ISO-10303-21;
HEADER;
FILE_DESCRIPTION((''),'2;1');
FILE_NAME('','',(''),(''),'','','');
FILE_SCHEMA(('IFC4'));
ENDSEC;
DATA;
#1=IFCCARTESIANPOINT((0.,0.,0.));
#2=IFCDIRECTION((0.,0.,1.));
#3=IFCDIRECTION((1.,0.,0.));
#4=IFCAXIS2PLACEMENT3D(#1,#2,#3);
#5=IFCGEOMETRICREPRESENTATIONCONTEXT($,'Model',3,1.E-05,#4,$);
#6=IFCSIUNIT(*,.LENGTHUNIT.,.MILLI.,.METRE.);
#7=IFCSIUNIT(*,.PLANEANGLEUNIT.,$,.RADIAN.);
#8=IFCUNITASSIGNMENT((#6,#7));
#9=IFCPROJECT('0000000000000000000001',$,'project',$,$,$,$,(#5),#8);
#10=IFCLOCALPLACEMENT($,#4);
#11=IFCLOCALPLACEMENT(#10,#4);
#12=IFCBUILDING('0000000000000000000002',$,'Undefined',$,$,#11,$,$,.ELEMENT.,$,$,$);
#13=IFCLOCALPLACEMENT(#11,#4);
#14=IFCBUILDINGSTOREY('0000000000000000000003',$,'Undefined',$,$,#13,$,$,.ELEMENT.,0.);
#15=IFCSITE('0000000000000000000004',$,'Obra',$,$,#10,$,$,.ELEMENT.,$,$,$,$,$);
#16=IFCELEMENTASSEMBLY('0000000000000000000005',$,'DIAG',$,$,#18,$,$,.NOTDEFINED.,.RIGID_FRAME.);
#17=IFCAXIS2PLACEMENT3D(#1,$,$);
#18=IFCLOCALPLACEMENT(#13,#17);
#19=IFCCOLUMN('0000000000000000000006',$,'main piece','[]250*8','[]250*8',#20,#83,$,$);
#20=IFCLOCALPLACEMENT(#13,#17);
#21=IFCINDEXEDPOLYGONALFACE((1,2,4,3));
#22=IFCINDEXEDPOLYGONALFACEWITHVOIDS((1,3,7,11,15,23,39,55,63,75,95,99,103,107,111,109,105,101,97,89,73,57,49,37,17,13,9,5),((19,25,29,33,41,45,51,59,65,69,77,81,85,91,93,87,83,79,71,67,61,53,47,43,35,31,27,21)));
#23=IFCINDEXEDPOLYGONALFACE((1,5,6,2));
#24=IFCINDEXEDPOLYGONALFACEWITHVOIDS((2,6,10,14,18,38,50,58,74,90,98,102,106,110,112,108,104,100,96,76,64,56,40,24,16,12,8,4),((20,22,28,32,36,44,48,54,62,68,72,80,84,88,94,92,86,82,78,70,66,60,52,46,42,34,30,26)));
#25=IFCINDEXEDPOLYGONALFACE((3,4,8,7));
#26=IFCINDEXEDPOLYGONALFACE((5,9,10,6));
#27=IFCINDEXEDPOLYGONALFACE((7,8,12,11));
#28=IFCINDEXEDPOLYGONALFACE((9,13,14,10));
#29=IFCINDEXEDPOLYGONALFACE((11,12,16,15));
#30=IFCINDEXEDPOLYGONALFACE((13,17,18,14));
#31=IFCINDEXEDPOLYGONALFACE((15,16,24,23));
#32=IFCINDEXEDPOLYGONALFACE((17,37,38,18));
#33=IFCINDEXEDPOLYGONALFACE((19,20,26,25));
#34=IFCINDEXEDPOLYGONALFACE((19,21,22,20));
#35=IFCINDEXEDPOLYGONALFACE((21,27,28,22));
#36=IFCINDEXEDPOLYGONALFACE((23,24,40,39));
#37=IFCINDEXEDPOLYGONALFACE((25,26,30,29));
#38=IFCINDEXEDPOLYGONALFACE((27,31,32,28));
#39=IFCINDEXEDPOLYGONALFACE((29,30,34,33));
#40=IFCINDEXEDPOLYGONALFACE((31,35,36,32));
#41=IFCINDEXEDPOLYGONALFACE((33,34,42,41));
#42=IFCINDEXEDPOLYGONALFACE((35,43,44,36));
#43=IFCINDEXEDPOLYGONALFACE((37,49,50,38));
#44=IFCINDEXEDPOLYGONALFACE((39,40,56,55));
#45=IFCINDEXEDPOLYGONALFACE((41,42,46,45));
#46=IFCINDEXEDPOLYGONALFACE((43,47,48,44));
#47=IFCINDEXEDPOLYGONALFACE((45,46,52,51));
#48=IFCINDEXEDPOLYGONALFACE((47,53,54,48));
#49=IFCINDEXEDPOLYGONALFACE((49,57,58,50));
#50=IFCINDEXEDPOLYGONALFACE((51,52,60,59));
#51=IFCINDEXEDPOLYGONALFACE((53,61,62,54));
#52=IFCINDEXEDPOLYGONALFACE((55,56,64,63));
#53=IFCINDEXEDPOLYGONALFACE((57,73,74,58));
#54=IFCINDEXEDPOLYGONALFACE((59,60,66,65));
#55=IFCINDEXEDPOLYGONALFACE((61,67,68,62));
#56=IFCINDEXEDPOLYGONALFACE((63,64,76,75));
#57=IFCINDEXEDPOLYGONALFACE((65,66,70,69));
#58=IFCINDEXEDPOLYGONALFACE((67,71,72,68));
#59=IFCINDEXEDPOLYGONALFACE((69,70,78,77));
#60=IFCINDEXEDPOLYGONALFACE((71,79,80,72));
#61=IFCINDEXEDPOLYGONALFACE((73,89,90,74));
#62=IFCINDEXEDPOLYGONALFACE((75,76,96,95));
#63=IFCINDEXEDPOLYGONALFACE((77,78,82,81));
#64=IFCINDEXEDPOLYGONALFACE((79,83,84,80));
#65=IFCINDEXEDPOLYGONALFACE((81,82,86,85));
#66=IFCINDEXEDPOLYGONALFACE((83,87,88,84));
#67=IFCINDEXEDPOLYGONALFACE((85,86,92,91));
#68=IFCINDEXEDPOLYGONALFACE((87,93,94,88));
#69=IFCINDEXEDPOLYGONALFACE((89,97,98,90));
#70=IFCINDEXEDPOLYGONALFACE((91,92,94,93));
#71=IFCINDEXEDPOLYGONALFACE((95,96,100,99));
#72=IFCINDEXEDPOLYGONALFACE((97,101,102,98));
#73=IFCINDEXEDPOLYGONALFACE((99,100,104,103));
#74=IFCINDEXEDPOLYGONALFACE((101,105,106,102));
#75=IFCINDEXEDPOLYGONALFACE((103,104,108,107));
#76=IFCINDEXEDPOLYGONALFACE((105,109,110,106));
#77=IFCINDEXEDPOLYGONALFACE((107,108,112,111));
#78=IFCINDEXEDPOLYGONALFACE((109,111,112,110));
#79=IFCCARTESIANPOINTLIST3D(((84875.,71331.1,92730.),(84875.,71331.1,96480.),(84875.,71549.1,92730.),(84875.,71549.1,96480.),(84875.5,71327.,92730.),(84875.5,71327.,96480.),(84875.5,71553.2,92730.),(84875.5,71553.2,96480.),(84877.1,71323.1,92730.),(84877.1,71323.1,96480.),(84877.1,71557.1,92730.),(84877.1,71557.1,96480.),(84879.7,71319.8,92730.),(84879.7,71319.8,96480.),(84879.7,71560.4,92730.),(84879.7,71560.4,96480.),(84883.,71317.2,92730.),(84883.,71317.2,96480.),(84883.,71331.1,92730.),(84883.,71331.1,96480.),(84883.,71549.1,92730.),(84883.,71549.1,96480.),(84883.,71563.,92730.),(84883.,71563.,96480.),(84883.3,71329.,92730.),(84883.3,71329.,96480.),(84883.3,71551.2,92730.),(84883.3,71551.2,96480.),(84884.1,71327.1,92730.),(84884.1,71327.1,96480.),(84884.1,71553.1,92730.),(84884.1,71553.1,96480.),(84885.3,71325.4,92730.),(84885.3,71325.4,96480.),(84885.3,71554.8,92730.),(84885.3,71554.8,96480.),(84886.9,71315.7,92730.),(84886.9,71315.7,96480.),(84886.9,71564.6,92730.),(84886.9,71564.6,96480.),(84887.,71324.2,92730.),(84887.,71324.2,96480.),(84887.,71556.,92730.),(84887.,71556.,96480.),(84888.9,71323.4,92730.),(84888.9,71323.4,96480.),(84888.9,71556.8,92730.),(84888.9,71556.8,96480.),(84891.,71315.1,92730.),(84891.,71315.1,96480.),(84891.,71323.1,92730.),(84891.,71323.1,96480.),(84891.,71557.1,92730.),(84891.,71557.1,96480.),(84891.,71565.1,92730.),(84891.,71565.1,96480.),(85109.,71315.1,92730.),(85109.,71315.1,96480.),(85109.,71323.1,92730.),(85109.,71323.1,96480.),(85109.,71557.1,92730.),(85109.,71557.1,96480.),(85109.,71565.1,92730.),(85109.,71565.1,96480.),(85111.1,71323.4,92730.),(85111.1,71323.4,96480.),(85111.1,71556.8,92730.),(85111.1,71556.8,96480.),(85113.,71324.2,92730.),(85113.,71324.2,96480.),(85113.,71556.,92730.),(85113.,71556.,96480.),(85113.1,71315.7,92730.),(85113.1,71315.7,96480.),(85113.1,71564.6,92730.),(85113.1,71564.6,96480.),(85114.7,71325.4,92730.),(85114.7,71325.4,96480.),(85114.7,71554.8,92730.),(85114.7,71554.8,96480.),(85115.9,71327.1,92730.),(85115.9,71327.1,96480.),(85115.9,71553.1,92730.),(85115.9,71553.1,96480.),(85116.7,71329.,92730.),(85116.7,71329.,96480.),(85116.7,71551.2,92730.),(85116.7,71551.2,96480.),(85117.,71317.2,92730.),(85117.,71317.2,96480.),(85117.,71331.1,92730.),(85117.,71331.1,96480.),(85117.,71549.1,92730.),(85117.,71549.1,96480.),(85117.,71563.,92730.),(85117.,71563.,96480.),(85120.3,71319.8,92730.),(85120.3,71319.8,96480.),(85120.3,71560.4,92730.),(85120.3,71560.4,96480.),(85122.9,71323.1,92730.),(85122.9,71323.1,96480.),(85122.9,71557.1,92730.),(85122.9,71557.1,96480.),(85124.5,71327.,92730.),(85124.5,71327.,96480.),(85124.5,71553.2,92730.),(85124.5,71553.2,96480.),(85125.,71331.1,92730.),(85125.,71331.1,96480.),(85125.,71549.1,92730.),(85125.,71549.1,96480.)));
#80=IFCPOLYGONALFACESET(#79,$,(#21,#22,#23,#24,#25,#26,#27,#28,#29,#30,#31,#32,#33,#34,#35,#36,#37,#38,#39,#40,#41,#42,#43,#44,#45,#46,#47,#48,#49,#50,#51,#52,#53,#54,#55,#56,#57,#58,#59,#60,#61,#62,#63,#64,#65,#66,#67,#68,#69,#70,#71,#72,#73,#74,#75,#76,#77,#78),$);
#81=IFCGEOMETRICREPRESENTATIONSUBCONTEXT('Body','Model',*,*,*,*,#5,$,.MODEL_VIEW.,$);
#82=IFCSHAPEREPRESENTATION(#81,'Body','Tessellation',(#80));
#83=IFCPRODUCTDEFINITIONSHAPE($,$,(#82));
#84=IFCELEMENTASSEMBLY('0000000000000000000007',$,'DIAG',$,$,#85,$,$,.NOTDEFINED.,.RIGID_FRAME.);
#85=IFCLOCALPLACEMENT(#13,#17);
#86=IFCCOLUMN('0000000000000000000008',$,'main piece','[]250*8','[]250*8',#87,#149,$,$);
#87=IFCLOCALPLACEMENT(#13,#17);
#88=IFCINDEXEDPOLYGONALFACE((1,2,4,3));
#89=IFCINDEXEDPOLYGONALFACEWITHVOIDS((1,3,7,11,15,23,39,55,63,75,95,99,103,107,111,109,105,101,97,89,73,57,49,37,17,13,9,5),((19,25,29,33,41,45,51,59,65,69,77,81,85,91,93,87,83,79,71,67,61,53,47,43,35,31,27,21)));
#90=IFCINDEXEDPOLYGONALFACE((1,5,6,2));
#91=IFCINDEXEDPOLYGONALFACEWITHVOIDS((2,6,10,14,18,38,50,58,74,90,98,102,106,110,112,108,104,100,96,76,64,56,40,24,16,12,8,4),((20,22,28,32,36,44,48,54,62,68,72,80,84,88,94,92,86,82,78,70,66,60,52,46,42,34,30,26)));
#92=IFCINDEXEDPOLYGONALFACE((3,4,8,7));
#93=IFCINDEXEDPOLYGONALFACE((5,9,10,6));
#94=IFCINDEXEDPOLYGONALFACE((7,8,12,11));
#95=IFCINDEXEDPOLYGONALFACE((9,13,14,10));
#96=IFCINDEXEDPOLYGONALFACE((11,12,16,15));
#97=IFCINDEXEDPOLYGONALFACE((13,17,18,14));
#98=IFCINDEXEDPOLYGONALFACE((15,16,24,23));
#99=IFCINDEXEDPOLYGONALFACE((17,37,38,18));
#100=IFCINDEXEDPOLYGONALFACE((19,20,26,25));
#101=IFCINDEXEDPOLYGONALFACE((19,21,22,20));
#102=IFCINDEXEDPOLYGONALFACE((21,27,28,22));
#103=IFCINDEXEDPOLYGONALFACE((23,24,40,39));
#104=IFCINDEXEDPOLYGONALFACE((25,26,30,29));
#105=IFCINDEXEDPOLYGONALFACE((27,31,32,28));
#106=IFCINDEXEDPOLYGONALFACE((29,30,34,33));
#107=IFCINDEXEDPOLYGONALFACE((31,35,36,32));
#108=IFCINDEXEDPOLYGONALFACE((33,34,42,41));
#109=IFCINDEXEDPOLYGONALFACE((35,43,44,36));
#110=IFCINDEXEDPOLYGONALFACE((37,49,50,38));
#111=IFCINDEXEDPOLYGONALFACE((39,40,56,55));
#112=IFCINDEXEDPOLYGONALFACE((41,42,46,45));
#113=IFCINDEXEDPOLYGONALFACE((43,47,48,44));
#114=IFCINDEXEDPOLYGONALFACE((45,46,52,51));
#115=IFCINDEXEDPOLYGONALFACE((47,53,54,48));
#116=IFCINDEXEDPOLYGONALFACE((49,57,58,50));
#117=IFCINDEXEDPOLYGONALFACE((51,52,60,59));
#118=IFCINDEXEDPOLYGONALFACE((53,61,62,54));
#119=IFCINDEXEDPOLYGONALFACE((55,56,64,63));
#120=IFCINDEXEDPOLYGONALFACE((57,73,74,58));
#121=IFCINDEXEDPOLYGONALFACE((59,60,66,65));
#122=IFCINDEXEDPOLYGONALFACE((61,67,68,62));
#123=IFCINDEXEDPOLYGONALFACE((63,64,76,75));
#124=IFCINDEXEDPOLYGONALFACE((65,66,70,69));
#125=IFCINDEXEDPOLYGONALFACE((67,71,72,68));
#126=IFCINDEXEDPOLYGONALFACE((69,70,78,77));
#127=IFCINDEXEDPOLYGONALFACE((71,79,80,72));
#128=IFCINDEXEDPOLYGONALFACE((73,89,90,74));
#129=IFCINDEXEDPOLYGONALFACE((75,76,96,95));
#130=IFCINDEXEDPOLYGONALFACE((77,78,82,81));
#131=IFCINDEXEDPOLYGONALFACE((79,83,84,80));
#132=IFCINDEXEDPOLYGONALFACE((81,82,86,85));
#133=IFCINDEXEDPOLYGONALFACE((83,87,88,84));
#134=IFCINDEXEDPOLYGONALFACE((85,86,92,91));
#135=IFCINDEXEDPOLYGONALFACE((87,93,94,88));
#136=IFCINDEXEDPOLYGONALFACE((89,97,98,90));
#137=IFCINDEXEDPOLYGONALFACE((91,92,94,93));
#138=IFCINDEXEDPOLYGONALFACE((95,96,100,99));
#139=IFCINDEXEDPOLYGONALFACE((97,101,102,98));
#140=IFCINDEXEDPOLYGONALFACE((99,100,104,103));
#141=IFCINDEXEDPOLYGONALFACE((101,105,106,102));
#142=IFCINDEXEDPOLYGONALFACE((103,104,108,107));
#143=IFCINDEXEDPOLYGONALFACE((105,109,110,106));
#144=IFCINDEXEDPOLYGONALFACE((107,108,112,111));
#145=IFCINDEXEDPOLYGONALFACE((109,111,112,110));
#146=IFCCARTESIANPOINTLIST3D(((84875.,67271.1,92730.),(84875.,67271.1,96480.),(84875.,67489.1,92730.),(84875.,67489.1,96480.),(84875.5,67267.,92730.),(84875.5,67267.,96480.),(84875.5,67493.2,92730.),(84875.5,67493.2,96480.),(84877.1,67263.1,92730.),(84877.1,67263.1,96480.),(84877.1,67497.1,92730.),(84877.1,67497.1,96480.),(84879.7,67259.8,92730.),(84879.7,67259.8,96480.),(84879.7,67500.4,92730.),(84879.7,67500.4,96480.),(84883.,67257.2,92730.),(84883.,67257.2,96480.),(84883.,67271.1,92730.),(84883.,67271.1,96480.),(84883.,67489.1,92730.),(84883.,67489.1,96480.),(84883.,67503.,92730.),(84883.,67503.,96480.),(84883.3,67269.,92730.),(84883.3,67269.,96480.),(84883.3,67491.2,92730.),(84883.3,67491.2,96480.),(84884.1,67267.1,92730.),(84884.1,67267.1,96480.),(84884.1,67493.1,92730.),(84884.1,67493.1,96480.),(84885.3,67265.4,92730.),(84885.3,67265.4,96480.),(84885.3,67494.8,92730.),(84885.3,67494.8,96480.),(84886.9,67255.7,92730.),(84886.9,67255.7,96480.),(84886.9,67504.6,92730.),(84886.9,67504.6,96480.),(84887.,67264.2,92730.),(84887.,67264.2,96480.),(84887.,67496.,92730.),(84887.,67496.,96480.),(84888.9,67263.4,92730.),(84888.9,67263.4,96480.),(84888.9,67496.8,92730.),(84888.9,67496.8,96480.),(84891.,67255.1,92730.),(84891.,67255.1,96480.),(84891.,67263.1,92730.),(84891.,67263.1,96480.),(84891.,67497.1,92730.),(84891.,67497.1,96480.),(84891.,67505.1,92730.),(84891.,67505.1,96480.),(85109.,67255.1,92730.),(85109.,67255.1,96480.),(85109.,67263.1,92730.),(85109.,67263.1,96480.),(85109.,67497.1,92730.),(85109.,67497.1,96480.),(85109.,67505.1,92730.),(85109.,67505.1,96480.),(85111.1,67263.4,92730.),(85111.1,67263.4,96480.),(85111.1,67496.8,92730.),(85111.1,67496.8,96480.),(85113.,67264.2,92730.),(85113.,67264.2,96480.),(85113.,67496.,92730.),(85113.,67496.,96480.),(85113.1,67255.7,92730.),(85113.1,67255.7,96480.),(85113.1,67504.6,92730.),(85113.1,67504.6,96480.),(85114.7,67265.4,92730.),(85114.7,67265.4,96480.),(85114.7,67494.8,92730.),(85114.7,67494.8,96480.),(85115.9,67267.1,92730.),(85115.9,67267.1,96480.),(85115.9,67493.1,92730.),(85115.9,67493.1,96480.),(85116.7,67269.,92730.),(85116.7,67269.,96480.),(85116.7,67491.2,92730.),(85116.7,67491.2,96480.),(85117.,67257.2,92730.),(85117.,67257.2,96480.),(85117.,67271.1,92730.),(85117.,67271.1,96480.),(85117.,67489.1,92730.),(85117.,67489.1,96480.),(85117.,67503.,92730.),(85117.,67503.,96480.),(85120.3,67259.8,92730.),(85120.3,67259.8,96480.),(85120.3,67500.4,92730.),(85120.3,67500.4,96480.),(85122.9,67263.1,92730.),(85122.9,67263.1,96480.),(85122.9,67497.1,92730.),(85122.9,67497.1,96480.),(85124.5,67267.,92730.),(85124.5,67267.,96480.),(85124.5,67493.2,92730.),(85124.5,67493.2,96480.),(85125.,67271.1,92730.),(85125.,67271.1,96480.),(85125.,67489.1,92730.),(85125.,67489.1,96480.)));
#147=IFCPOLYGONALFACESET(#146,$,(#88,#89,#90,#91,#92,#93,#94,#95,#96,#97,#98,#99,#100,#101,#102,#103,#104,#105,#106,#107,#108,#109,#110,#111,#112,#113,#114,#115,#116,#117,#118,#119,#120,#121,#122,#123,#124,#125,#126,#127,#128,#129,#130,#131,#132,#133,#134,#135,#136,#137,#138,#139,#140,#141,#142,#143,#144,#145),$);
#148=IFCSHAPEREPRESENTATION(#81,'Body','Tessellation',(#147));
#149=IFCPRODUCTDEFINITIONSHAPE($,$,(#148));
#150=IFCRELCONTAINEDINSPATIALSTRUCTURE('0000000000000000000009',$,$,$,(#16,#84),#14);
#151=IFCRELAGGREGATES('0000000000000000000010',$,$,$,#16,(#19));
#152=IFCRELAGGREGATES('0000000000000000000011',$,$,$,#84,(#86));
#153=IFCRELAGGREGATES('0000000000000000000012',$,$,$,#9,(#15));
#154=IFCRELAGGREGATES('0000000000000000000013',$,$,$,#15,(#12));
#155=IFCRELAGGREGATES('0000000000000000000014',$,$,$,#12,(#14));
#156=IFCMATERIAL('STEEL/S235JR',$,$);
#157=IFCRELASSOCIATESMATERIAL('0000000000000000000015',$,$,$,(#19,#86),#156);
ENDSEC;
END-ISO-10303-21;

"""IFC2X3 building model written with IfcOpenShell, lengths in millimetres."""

from ifc_helpers import new_model, si_unit, frame, origin_with_axes, origin_2d_with_axis, place, context, subcontext, project, spatial, hollow_rectangle, extrude, material, element, aggregate, save


model = new_model("IFC2X3")

# Units and contexts
model_context = context("Model", 3, precision=1e-05, world=origin_with_axes())
body_context = subcontext(model_context, "Body", "Model", "MODEL_VIEW")
ifc_project = project(units=[si_unit("LENGTHUNIT", "METRE", prefix="MILLI"), si_unit("PLANEANGLEUNIT", "RADIAN")], contexts=[model_context])

# Site, building, storey
site_placement = place(None, origin_with_axes())
site = spatial("IfcSite", under=ifc_project, at=site_placement, Name="Obra", CompositionType="ELEMENT")
building_placement = place(site_placement, origin_with_axes())
building = spatial("IfcBuilding", under=site, at=building_placement, Name="Undefined", CompositionType="ELEMENT")
storey_placement = place(building_placement, origin_with_axes())
storey = spatial("IfcBuildingStorey", under=building, at=storey_placement, Name="Undefined", CompositionType="ELEMENT", Elevation=0.0)

# Element assemblies, columns
ifc_material = material(Name="STEEL/S235JR")
assembly_1_placement = place(storey_placement, origin_with_axes())
assembly_1 = element("IfcElementAssembly", 1, at=assembly_1_placement, inside=storey, Name="DIAG", AssemblyPlace="NOTDEFINED", PredefinedType="RIGID_FRAME")
column_1_placement = place(assembly_1_placement, frame((85000.0, 71440.1, 92730.0), z_axis=(0.0, 0.0, 1.0), x_axis=(-1.0, 0.0, 0.0)))
column_1 = element("IfcColumn", 2, at=column_1_placement, material=ifc_material, Name="main piece", Description="[]250*8", ObjectType="[]250*8", context=body_context, shape_type="SweptSolid", body=[
    extrude(hollow_rectangle(XDim=250.0, YDim=250.0, WallThickness=8.0, InnerFilletRadius=8.0, OuterFilletRadius=16.0, at=origin_2d_with_axis()), frame((0.0, 0.0, 3750.0), z_axis=(0.0, 0.0, -1.0), x_axis=(0.0, 1.0, 0.0)), (0.0, 0.0, 1.0), 3750.0),
])
aggregate(assembly_1, [column_1])
assembly_2_placement = place(storey_placement, origin_with_axes())
assembly_2 = element("IfcElementAssembly", 3, at=assembly_2_placement, inside=storey, Name="DIAG", AssemblyPlace="NOTDEFINED", PredefinedType="RIGID_FRAME")
column_2_placement = place(assembly_2_placement, frame((85000.0, 67380.1, 92730.0), z_axis=(0.0, 0.0, 1.0), x_axis=(-1.0, 0.0, 0.0)))
column_2 = element("IfcColumn", 4, at=column_2_placement, material=ifc_material, Name="main piece", Description="[]250*8", ObjectType="[]250*8", context=body_context, shape_type="SweptSolid", body=[
    extrude(hollow_rectangle(XDim=250.0, YDim=250.0, WallThickness=8.0, InnerFilletRadius=8.0, OuterFilletRadius=16.0, at=origin_2d_with_axis()), frame((0.0, 0.0, 3750.0), z_axis=(0.0, 0.0, -1.0), x_axis=(0.0, 1.0, 0.0)), (0.0, 0.0, 1.0), 3750.0),
])
aggregate(assembly_2, [column_2])

save(model, "model.ifc")
